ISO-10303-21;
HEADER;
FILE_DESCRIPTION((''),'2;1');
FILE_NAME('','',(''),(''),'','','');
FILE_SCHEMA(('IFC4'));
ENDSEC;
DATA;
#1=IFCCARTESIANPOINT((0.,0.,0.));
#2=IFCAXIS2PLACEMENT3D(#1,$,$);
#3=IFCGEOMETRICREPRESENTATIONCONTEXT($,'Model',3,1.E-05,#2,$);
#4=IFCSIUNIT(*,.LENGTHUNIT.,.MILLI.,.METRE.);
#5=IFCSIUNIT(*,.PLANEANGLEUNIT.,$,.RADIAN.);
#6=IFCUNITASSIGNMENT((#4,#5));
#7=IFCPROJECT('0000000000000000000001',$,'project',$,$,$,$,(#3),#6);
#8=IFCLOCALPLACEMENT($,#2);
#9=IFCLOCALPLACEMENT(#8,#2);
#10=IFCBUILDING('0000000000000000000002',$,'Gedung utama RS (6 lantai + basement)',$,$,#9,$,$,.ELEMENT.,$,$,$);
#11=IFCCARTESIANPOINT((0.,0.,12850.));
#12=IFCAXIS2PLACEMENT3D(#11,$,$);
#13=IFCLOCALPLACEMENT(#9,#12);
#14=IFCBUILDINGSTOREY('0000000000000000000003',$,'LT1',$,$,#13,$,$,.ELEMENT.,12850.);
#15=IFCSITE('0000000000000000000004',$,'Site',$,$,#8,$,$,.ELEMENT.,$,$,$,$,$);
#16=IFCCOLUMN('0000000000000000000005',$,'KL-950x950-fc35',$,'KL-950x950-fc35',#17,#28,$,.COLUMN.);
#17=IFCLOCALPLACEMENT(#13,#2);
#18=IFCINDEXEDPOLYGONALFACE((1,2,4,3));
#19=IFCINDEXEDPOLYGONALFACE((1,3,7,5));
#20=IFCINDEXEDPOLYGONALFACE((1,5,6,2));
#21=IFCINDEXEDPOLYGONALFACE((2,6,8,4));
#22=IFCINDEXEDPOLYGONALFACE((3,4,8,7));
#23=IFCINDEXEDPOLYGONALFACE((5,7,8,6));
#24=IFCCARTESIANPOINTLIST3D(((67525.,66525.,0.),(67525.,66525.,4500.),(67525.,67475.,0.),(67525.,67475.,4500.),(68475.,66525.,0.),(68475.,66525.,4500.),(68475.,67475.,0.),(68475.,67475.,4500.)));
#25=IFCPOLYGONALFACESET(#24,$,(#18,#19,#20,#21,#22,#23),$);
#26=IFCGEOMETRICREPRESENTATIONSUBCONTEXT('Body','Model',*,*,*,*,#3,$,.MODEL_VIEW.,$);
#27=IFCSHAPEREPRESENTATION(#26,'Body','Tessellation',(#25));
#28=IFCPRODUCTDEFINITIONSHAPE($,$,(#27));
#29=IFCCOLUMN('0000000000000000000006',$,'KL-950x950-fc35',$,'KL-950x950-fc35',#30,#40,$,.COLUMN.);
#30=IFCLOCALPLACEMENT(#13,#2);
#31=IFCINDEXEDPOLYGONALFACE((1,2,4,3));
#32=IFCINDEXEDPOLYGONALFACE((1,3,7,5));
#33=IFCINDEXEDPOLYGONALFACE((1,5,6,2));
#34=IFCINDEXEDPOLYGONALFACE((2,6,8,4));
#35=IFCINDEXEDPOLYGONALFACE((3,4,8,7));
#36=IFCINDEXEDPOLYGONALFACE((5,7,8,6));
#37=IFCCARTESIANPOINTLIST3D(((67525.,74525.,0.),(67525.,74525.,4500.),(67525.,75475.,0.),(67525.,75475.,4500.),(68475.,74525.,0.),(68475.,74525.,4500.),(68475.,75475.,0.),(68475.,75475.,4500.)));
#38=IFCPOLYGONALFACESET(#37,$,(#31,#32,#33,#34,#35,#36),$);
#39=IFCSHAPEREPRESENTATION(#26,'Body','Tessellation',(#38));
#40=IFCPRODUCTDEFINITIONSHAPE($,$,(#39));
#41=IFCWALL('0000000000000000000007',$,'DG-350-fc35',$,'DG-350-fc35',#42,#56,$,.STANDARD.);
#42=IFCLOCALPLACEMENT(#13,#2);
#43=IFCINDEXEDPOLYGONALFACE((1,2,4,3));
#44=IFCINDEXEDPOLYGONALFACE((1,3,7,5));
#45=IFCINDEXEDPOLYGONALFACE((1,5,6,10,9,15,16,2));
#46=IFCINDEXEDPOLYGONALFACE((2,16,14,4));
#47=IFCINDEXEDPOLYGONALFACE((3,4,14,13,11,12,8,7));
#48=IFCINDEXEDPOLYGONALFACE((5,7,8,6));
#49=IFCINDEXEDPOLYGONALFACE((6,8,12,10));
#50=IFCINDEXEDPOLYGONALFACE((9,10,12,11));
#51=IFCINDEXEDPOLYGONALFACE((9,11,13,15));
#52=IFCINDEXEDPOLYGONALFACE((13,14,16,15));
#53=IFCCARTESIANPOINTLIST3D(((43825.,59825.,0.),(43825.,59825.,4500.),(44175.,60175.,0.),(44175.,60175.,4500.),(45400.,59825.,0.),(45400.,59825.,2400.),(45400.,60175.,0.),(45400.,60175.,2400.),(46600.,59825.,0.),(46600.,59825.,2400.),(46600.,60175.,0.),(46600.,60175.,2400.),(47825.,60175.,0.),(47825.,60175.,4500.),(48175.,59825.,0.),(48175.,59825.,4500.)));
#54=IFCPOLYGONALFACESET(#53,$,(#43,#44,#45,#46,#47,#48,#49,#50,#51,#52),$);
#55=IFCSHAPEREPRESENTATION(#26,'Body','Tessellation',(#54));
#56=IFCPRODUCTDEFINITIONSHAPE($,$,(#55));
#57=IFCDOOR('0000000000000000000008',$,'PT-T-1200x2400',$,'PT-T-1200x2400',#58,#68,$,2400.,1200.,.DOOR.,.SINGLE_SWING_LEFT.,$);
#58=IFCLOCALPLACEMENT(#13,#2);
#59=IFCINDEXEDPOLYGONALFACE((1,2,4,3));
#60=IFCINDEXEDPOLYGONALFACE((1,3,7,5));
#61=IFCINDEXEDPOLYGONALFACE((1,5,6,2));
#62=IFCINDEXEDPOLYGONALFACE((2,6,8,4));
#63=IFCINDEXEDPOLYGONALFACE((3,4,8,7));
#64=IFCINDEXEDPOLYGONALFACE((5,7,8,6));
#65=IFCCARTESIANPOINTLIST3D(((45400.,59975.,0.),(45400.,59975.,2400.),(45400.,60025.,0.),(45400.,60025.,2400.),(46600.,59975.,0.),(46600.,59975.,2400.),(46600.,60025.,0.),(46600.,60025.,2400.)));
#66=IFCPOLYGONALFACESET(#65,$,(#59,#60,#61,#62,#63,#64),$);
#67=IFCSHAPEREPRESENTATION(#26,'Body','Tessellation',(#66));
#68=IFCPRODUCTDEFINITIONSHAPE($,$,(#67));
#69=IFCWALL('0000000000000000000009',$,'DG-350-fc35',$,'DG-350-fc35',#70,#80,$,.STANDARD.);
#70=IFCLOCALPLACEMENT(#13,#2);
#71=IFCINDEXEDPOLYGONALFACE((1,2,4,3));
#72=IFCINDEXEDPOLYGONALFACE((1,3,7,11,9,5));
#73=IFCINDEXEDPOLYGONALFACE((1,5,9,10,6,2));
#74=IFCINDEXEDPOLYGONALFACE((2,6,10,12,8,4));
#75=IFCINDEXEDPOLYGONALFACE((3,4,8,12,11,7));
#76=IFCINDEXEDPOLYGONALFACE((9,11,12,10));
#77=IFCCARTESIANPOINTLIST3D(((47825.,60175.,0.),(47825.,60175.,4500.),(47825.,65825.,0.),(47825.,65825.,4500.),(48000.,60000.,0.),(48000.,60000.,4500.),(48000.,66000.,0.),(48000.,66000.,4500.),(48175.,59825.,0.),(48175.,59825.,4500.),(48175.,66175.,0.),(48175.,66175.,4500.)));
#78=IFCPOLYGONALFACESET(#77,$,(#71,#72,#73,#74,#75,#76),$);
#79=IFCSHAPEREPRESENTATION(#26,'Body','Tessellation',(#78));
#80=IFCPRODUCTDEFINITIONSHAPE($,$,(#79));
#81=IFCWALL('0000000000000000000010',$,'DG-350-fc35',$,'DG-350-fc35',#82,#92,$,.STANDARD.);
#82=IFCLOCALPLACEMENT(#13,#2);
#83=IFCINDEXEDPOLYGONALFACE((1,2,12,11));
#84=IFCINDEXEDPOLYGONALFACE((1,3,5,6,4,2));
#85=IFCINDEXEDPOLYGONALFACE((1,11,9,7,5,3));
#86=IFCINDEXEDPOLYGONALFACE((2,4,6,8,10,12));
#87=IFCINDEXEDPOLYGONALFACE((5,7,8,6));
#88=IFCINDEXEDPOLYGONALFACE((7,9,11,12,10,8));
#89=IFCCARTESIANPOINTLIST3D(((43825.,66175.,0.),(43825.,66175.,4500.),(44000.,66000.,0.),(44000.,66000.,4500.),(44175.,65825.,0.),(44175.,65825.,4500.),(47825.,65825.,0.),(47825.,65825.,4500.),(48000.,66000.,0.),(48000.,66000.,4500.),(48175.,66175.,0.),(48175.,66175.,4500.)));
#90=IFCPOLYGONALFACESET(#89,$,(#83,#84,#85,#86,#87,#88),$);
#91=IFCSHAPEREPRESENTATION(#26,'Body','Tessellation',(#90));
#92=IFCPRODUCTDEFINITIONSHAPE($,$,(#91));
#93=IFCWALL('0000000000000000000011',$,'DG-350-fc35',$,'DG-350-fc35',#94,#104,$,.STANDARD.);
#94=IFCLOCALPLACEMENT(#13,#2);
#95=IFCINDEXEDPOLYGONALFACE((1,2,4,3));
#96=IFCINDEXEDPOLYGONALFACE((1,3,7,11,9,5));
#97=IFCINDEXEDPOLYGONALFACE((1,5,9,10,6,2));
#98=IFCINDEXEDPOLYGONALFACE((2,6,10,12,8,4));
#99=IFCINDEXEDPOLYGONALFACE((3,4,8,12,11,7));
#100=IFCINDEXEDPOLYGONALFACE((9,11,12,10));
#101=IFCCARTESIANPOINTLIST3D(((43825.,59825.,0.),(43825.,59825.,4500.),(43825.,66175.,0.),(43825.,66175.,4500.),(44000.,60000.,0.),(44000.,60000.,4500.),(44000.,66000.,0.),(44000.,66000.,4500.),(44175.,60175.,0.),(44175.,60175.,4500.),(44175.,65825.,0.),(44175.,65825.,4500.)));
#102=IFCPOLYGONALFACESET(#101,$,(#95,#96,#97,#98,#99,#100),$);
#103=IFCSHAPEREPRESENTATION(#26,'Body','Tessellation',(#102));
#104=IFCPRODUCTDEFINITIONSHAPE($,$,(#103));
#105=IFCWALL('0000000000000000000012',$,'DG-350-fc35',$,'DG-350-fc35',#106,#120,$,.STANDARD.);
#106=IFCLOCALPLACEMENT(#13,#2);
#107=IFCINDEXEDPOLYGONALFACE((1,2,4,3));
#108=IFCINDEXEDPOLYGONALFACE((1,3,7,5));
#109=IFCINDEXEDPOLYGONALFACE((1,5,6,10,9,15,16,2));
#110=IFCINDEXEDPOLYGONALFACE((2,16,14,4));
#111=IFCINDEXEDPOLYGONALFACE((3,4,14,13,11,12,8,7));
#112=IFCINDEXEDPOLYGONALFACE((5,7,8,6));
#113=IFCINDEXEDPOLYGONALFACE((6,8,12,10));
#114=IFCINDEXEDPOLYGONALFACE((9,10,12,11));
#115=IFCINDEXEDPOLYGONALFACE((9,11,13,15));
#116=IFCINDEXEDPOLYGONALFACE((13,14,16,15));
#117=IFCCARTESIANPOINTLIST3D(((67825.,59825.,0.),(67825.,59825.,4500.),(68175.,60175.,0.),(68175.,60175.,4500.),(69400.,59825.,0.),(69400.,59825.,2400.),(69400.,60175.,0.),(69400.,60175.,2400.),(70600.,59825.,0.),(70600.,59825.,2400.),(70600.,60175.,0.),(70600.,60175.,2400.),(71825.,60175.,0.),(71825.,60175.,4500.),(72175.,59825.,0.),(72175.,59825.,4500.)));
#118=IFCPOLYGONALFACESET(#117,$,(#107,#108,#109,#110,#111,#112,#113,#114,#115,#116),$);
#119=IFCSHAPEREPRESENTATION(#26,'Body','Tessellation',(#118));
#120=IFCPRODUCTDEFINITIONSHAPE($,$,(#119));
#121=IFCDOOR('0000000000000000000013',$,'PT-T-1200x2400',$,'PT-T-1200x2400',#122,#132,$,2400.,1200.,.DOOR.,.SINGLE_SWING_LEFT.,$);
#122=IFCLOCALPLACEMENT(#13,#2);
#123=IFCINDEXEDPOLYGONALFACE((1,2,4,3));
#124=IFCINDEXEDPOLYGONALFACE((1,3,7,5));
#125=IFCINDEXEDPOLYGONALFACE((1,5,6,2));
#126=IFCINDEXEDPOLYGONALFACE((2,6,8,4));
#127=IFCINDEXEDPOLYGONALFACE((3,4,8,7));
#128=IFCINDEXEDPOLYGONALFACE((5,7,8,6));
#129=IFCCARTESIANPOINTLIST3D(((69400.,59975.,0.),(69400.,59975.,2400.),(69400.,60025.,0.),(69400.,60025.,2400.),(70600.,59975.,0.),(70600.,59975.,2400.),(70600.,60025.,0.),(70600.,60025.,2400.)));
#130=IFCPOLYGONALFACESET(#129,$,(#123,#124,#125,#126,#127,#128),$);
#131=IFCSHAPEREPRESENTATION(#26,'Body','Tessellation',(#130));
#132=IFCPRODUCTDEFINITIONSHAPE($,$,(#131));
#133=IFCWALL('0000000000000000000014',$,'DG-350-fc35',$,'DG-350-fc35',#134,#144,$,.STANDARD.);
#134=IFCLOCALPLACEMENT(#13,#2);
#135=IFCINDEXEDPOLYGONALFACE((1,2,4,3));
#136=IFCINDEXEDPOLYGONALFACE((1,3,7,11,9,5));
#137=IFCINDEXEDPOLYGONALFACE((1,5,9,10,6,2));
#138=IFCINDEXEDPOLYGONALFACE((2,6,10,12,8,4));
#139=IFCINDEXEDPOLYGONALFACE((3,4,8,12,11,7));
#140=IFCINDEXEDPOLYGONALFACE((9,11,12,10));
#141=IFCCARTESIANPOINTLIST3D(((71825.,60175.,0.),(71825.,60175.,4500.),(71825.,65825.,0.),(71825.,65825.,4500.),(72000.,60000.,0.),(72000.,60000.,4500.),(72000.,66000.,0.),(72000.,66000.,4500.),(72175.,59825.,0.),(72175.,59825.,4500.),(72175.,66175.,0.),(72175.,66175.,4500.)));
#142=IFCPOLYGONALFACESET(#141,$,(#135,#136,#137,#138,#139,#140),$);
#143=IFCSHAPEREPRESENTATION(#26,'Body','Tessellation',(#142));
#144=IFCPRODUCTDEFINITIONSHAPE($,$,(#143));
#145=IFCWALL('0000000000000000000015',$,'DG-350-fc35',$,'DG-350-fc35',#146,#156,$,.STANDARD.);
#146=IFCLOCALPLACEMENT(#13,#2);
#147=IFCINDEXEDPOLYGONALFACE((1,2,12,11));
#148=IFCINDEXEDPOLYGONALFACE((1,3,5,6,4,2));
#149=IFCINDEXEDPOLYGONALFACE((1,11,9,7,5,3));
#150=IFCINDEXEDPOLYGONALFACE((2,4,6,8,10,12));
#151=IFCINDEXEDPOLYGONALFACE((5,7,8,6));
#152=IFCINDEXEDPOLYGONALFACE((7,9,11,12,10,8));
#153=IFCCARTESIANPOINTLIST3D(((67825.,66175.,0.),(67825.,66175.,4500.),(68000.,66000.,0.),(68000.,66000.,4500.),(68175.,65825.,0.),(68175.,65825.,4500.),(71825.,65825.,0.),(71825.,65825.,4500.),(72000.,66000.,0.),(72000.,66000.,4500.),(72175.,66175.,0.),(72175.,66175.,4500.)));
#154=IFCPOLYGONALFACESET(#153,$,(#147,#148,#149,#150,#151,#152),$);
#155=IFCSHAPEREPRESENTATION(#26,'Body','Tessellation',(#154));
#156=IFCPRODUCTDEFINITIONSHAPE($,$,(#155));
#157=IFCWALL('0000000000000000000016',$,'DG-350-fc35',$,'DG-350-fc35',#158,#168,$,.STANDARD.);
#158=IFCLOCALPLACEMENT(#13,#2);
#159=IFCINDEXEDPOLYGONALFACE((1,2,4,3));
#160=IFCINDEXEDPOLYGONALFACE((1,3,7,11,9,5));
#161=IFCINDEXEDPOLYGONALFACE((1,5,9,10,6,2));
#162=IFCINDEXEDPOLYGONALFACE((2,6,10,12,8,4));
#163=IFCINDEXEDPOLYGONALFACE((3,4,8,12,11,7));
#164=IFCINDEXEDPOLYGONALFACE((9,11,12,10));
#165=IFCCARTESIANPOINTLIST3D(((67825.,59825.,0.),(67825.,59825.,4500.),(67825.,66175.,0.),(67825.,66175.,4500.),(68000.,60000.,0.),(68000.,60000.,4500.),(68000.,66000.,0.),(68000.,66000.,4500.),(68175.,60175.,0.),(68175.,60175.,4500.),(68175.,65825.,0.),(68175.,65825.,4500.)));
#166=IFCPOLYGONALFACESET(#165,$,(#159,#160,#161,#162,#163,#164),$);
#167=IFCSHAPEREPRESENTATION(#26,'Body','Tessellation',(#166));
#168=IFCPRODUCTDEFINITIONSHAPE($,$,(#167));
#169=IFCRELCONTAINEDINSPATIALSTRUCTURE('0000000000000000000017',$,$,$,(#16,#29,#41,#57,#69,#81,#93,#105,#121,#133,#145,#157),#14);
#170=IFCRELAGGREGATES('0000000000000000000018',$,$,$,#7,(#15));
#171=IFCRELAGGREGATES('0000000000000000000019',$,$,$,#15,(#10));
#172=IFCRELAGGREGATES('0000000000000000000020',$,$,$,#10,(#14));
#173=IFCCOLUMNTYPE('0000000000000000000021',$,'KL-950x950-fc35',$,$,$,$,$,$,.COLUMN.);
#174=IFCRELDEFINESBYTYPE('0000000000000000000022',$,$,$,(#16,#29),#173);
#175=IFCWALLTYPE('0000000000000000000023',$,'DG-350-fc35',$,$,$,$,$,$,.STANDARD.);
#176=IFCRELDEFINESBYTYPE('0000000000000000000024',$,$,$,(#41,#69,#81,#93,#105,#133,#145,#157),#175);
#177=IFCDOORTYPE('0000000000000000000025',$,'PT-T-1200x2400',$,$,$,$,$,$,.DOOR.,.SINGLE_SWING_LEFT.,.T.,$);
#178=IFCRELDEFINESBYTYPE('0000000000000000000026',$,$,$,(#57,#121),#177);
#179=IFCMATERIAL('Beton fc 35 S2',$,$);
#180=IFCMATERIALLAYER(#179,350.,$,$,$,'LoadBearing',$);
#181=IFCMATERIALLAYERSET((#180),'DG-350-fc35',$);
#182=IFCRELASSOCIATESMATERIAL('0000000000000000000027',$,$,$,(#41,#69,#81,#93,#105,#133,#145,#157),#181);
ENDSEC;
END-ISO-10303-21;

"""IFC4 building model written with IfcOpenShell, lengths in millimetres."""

from ifc_helpers import new_model, si_unit, frame, frame_2d, origin, origin_2d, place, context, subcontext, project, spatial, polyline, rectangle, outline, extrude, material, layer, layer_set, layer_usage, material_profile, profile_set, profile_usage, type_object, element, fill, save


model = new_model("IFC4")

# Units and contexts
model_context = context("Model", 3, precision=1e-05, world=origin())
body_context = subcontext(model_context, "Body", "Model", "MODEL_VIEW")
ifc_project = project(units=[si_unit("LENGTHUNIT", "METRE", prefix="MILLI"), si_unit("PLANEANGLEUNIT", "RADIAN")], contexts=[model_context])

# Site, building, storey
site_placement = place(None, origin())
site = spatial("IfcSite", under=ifc_project, at=site_placement, Name="Site", CompositionType="ELEMENT")
building_placement = place(site_placement, origin())
building = spatial("IfcBuilding", under=site, at=building_placement, Name="Gedung utama RS (6 lantai + basement)", CompositionType="ELEMENT")
storey_placement = place(building_placement, frame((0.0, 0.0, 12850.0)))
storey = spatial("IfcBuildingStorey", under=building, at=storey_placement, Name="LT1", CompositionType="ELEMENT", Elevation=12850.0)

# Columns
ifc_material_profile_1 = material_profile(None, rectangle(XDim=950.0, YDim=950.0, at=origin_2d()), Name="KL-950x950-fc35")
ifc_profile_set_1 = profile_set([ifc_material_profile_1], Name="KL-950x950-fc35")
ifc_profile_usage_1 = profile_usage(ifc_profile_set_1, cardinal=5)
column_type_1 = type_object("IfcColumnType", Name="KL-950x950-fc35", PredefinedType="COLUMN", material=ifc_profile_set_1)
for number, where, z_axis, x_axis, name in (
    (1, (68000.0, 67000.0, 0.0), (0.0, 0.0, 1.0), (1.0, 0.0, 0.0), "KL-950x950-fc35"),
    (2, (68000.0, 75000.0, 0.0), (0.0, 0.0, 1.0), (1.0, 0.0, 0.0), "KL-950x950-fc35"),
):
    element("IfcColumn", number, at=place(storey_placement, frame(where, z_axis=z_axis, x_axis=x_axis)), inside=storey, type_object=column_type_1, material=ifc_profile_usage_1, Name=name, ObjectType="KL-950x950-fc35", PredefinedType="COLUMN", context=body_context, shape_type="SweptSolid", body=[
        extrude(rectangle(XDim=950.0, YDim=950.0, at=origin_2d()), origin(), (0.0, 0.0, 1.0), 4500.0),
    ])

# Wall, opening, door
ifc_material = material(Name="Beton fc 35 S2")
ifc_layer = layer(ifc_material, 350.0, Category="LoadBearing")
ifc_layer_set = layer_set([ifc_layer], Name="DG-350-fc35")
ifc_layer_usage = layer_usage(ifc_layer_set, "AXIS2", "NEGATIVE", 175.0)
wall_type = type_object("IfcWallType", Name="DG-350-fc35", PredefinedType="STANDARD")
wall_1_placement = place(storey_placement, frame((44000.0, 60000.0, 0.0), z_axis=(0.0, 0.0, 1.0), x_axis=(1.0, 0.0, 0.0)))
wall_1 = element("IfcWall", 3, at=wall_1_placement, inside=storey, type_object=wall_type, material=ifc_layer_usage, Name="DG-350-fc35", ObjectType="DG-350-fc35", PredefinedType="STANDARD", context=body_context, shape_type="SweptSolid", body=[
    extrude(outline(polyline([(-175.0, -175.0), (0.0, 0.0), (175.0, 175.0), (3825.0, 175.0), (4000.0, 0.0), (4175.0, -175.0), (-175.0, -175.0)])), origin(), (0.0, 0.0, 1.0), 4500.0),
])
opening_1_placement = place(wall_1_placement, frame((1400.0, 0.0, 0.0), z_axis=(0.0, 0.0, 1.0), x_axis=(1.0, 0.0, 0.0)))
opening_1 = element("IfcOpeningElement", 4, at=opening_1_placement, cuts=wall_1, PredefinedType="OPENING", context=body_context, shape_type="SweptSolid", body=[
    extrude(rectangle(XDim=1200.0, YDim=370.0, at=frame_2d((600.0, 0.0))), origin(), (0.0, 0.0, 1.0), 2400.0),
])
door_type = type_object("IfcDoorType", Name="PT-T-1200x2400", OperationType="SINGLE_SWING_LEFT", ParameterTakesPrecedence=True, PredefinedType="DOOR")
door_1_placement = place(opening_1_placement, origin())
door_1 = element("IfcDoor", 5, at=door_1_placement, inside=storey, type_object=door_type, Name="PT-T-1200x2400", ObjectType="PT-T-1200x2400", OperationType="SINGLE_SWING_LEFT", OverallHeight=2400.0, OverallWidth=1200.0, PredefinedType="DOOR", context=body_context, shape_type="SweptSolid", body=[
    extrude(rectangle(XDim=1200.0, YDim=50.0, at=frame_2d((600.0, 0.0))), origin(), (0.0, 0.0, 1.0), 2400.0),
])
fill(opening_1, door_1)

# Walls
wall_2_placement = place(storey_placement, frame((48000.0, 60000.0, 0.0), z_axis=(0.0, 0.0, 1.0), x_axis=(0.0, 1.0, 0.0)))
element("IfcWall", 6, at=wall_2_placement, inside=storey, type_object=wall_type, material=ifc_layer_usage, Name="DG-350-fc35", ObjectType="DG-350-fc35", PredefinedType="STANDARD", context=body_context, shape_type="SweptSolid", body=[
    extrude(outline(polyline([(-175.0, -175.0), (0.0, 0.0), (175.0, 175.0), (5825.0, 175.0), (6000.0, 0.0), (6175.0, -175.0), (-175.0, -175.0)])), origin(), (0.0, 0.0, 1.0), 4500.0),
])
wall_3_placement = place(storey_placement, frame((48000.0, 66000.0, 0.0), z_axis=(0.0, 0.0, 1.0), x_axis=(-1.0, 0.0, 0.0)))
element("IfcWall", 7, at=wall_3_placement, inside=storey, type_object=wall_type, material=ifc_layer_usage, Name="DG-350-fc35", ObjectType="DG-350-fc35", PredefinedType="STANDARD", context=body_context, shape_type="SweptSolid", body=[
    extrude(outline(polyline([(-175.0, -175.0), (0.0, 0.0), (175.0, 175.0), (3825.0, 175.0), (4000.0, 0.0), (4175.0, -175.0), (-175.0, -175.0)])), origin(), (0.0, 0.0, 1.0), 4500.0),
])
wall_4_placement = place(storey_placement, frame((44000.0, 66000.0, 0.0), z_axis=(0.0, 0.0, 1.0), x_axis=(0.0, -1.0, 0.0)))
element("IfcWall", 8, at=wall_4_placement, inside=storey, type_object=wall_type, material=ifc_layer_usage, Name="DG-350-fc35", ObjectType="DG-350-fc35", PredefinedType="STANDARD", context=body_context, shape_type="SweptSolid", body=[
    extrude(outline(polyline([(-175.0, -175.0), (0.0, 0.0), (175.0, 175.0), (5825.0, 175.0), (6000.0, 0.0), (6175.0, -175.0), (-175.0, -175.0)])), origin(), (0.0, 0.0, 1.0), 4500.0),
])

# Wall, opening, door
wall_5_placement = place(storey_placement, frame((68000.0, 60000.0, 0.0), z_axis=(0.0, 0.0, 1.0), x_axis=(1.0, 0.0, 0.0)))
wall_5 = element("IfcWall", 9, at=wall_5_placement, inside=storey, type_object=wall_type, material=ifc_layer_usage, Name="DG-350-fc35", ObjectType="DG-350-fc35", PredefinedType="STANDARD", context=body_context, shape_type="SweptSolid", body=[
    extrude(outline(polyline([(-175.0, -175.0), (0.0, 0.0), (175.0, 175.0), (3825.0, 175.0), (4000.0, 0.0), (4175.0, -175.0), (-175.0, -175.0)])), origin(), (0.0, 0.0, 1.0), 4500.0),
])
opening_2_placement = place(wall_5_placement, frame((1400.0, 0.0, 0.0), z_axis=(0.0, 0.0, 1.0), x_axis=(1.0, 0.0, 0.0)))
opening_2 = element("IfcOpeningElement", 10, at=opening_2_placement, cuts=wall_5, PredefinedType="OPENING", context=body_context, shape_type="SweptSolid", body=[
    extrude(rectangle(XDim=1200.0, YDim=370.0, at=frame_2d((600.0, 0.0))), origin(), (0.0, 0.0, 1.0), 2400.0),
])
door_2_placement = place(opening_2_placement, origin())
door_2 = element("IfcDoor", 11, at=door_2_placement, inside=storey, type_object=door_type, Name="PT-T-1200x2400", ObjectType="PT-T-1200x2400", OperationType="SINGLE_SWING_LEFT", OverallHeight=2400.0, OverallWidth=1200.0, PredefinedType="DOOR", context=body_context, shape_type="SweptSolid", body=[
    extrude(rectangle(XDim=1200.0, YDim=50.0, at=frame_2d((600.0, 0.0))), origin(), (0.0, 0.0, 1.0), 2400.0),
])
fill(opening_2, door_2)

# Walls
wall_6_placement = place(storey_placement, frame((72000.0, 60000.0, 0.0), z_axis=(0.0, 0.0, 1.0), x_axis=(0.0, 1.0, 0.0)))
element("IfcWall", 12, at=wall_6_placement, inside=storey, type_object=wall_type, material=ifc_layer_usage, Name="DG-350-fc35", ObjectType="DG-350-fc35", PredefinedType="STANDARD", context=body_context, shape_type="SweptSolid", body=[
    extrude(outline(polyline([(-175.0, -175.0), (0.0, 0.0), (175.0, 175.0), (5825.0, 175.0), (6000.0, 0.0), (6175.0, -175.0), (-175.0, -175.0)])), origin(), (0.0, 0.0, 1.0), 4500.0),
])
wall_7_placement = place(storey_placement, frame((72000.0, 66000.0, 0.0), z_axis=(0.0, 0.0, 1.0), x_axis=(-1.0, 0.0, 0.0)))
element("IfcWall", 13, at=wall_7_placement, inside=storey, type_object=wall_type, material=ifc_layer_usage, Name="DG-350-fc35", ObjectType="DG-350-fc35", PredefinedType="STANDARD", context=body_context, shape_type="SweptSolid", body=[
    extrude(outline(polyline([(-175.0, -175.0), (0.0, 0.0), (175.0, 175.0), (3825.0, 175.0), (4000.0, 0.0), (4175.0, -175.0), (-175.0, -175.0)])), origin(), (0.0, 0.0, 1.0), 4500.0),
])
wall_8_placement = place(storey_placement, frame((68000.0, 66000.0, 0.0), z_axis=(0.0, 0.0, 1.0), x_axis=(0.0, -1.0, 0.0)))
element("IfcWall", 14, at=wall_8_placement, inside=storey, type_object=wall_type, material=ifc_layer_usage, Name="DG-350-fc35", ObjectType="DG-350-fc35", PredefinedType="STANDARD", context=body_context, shape_type="SweptSolid", body=[
    extrude(outline(polyline([(-175.0, -175.0), (0.0, 0.0), (175.0, 175.0), (5825.0, 175.0), (6000.0, 0.0), (6175.0, -175.0), (-175.0, -175.0)])), origin(), (0.0, 0.0, 1.0), 4500.0),
])

save(model, "model.ifc")
